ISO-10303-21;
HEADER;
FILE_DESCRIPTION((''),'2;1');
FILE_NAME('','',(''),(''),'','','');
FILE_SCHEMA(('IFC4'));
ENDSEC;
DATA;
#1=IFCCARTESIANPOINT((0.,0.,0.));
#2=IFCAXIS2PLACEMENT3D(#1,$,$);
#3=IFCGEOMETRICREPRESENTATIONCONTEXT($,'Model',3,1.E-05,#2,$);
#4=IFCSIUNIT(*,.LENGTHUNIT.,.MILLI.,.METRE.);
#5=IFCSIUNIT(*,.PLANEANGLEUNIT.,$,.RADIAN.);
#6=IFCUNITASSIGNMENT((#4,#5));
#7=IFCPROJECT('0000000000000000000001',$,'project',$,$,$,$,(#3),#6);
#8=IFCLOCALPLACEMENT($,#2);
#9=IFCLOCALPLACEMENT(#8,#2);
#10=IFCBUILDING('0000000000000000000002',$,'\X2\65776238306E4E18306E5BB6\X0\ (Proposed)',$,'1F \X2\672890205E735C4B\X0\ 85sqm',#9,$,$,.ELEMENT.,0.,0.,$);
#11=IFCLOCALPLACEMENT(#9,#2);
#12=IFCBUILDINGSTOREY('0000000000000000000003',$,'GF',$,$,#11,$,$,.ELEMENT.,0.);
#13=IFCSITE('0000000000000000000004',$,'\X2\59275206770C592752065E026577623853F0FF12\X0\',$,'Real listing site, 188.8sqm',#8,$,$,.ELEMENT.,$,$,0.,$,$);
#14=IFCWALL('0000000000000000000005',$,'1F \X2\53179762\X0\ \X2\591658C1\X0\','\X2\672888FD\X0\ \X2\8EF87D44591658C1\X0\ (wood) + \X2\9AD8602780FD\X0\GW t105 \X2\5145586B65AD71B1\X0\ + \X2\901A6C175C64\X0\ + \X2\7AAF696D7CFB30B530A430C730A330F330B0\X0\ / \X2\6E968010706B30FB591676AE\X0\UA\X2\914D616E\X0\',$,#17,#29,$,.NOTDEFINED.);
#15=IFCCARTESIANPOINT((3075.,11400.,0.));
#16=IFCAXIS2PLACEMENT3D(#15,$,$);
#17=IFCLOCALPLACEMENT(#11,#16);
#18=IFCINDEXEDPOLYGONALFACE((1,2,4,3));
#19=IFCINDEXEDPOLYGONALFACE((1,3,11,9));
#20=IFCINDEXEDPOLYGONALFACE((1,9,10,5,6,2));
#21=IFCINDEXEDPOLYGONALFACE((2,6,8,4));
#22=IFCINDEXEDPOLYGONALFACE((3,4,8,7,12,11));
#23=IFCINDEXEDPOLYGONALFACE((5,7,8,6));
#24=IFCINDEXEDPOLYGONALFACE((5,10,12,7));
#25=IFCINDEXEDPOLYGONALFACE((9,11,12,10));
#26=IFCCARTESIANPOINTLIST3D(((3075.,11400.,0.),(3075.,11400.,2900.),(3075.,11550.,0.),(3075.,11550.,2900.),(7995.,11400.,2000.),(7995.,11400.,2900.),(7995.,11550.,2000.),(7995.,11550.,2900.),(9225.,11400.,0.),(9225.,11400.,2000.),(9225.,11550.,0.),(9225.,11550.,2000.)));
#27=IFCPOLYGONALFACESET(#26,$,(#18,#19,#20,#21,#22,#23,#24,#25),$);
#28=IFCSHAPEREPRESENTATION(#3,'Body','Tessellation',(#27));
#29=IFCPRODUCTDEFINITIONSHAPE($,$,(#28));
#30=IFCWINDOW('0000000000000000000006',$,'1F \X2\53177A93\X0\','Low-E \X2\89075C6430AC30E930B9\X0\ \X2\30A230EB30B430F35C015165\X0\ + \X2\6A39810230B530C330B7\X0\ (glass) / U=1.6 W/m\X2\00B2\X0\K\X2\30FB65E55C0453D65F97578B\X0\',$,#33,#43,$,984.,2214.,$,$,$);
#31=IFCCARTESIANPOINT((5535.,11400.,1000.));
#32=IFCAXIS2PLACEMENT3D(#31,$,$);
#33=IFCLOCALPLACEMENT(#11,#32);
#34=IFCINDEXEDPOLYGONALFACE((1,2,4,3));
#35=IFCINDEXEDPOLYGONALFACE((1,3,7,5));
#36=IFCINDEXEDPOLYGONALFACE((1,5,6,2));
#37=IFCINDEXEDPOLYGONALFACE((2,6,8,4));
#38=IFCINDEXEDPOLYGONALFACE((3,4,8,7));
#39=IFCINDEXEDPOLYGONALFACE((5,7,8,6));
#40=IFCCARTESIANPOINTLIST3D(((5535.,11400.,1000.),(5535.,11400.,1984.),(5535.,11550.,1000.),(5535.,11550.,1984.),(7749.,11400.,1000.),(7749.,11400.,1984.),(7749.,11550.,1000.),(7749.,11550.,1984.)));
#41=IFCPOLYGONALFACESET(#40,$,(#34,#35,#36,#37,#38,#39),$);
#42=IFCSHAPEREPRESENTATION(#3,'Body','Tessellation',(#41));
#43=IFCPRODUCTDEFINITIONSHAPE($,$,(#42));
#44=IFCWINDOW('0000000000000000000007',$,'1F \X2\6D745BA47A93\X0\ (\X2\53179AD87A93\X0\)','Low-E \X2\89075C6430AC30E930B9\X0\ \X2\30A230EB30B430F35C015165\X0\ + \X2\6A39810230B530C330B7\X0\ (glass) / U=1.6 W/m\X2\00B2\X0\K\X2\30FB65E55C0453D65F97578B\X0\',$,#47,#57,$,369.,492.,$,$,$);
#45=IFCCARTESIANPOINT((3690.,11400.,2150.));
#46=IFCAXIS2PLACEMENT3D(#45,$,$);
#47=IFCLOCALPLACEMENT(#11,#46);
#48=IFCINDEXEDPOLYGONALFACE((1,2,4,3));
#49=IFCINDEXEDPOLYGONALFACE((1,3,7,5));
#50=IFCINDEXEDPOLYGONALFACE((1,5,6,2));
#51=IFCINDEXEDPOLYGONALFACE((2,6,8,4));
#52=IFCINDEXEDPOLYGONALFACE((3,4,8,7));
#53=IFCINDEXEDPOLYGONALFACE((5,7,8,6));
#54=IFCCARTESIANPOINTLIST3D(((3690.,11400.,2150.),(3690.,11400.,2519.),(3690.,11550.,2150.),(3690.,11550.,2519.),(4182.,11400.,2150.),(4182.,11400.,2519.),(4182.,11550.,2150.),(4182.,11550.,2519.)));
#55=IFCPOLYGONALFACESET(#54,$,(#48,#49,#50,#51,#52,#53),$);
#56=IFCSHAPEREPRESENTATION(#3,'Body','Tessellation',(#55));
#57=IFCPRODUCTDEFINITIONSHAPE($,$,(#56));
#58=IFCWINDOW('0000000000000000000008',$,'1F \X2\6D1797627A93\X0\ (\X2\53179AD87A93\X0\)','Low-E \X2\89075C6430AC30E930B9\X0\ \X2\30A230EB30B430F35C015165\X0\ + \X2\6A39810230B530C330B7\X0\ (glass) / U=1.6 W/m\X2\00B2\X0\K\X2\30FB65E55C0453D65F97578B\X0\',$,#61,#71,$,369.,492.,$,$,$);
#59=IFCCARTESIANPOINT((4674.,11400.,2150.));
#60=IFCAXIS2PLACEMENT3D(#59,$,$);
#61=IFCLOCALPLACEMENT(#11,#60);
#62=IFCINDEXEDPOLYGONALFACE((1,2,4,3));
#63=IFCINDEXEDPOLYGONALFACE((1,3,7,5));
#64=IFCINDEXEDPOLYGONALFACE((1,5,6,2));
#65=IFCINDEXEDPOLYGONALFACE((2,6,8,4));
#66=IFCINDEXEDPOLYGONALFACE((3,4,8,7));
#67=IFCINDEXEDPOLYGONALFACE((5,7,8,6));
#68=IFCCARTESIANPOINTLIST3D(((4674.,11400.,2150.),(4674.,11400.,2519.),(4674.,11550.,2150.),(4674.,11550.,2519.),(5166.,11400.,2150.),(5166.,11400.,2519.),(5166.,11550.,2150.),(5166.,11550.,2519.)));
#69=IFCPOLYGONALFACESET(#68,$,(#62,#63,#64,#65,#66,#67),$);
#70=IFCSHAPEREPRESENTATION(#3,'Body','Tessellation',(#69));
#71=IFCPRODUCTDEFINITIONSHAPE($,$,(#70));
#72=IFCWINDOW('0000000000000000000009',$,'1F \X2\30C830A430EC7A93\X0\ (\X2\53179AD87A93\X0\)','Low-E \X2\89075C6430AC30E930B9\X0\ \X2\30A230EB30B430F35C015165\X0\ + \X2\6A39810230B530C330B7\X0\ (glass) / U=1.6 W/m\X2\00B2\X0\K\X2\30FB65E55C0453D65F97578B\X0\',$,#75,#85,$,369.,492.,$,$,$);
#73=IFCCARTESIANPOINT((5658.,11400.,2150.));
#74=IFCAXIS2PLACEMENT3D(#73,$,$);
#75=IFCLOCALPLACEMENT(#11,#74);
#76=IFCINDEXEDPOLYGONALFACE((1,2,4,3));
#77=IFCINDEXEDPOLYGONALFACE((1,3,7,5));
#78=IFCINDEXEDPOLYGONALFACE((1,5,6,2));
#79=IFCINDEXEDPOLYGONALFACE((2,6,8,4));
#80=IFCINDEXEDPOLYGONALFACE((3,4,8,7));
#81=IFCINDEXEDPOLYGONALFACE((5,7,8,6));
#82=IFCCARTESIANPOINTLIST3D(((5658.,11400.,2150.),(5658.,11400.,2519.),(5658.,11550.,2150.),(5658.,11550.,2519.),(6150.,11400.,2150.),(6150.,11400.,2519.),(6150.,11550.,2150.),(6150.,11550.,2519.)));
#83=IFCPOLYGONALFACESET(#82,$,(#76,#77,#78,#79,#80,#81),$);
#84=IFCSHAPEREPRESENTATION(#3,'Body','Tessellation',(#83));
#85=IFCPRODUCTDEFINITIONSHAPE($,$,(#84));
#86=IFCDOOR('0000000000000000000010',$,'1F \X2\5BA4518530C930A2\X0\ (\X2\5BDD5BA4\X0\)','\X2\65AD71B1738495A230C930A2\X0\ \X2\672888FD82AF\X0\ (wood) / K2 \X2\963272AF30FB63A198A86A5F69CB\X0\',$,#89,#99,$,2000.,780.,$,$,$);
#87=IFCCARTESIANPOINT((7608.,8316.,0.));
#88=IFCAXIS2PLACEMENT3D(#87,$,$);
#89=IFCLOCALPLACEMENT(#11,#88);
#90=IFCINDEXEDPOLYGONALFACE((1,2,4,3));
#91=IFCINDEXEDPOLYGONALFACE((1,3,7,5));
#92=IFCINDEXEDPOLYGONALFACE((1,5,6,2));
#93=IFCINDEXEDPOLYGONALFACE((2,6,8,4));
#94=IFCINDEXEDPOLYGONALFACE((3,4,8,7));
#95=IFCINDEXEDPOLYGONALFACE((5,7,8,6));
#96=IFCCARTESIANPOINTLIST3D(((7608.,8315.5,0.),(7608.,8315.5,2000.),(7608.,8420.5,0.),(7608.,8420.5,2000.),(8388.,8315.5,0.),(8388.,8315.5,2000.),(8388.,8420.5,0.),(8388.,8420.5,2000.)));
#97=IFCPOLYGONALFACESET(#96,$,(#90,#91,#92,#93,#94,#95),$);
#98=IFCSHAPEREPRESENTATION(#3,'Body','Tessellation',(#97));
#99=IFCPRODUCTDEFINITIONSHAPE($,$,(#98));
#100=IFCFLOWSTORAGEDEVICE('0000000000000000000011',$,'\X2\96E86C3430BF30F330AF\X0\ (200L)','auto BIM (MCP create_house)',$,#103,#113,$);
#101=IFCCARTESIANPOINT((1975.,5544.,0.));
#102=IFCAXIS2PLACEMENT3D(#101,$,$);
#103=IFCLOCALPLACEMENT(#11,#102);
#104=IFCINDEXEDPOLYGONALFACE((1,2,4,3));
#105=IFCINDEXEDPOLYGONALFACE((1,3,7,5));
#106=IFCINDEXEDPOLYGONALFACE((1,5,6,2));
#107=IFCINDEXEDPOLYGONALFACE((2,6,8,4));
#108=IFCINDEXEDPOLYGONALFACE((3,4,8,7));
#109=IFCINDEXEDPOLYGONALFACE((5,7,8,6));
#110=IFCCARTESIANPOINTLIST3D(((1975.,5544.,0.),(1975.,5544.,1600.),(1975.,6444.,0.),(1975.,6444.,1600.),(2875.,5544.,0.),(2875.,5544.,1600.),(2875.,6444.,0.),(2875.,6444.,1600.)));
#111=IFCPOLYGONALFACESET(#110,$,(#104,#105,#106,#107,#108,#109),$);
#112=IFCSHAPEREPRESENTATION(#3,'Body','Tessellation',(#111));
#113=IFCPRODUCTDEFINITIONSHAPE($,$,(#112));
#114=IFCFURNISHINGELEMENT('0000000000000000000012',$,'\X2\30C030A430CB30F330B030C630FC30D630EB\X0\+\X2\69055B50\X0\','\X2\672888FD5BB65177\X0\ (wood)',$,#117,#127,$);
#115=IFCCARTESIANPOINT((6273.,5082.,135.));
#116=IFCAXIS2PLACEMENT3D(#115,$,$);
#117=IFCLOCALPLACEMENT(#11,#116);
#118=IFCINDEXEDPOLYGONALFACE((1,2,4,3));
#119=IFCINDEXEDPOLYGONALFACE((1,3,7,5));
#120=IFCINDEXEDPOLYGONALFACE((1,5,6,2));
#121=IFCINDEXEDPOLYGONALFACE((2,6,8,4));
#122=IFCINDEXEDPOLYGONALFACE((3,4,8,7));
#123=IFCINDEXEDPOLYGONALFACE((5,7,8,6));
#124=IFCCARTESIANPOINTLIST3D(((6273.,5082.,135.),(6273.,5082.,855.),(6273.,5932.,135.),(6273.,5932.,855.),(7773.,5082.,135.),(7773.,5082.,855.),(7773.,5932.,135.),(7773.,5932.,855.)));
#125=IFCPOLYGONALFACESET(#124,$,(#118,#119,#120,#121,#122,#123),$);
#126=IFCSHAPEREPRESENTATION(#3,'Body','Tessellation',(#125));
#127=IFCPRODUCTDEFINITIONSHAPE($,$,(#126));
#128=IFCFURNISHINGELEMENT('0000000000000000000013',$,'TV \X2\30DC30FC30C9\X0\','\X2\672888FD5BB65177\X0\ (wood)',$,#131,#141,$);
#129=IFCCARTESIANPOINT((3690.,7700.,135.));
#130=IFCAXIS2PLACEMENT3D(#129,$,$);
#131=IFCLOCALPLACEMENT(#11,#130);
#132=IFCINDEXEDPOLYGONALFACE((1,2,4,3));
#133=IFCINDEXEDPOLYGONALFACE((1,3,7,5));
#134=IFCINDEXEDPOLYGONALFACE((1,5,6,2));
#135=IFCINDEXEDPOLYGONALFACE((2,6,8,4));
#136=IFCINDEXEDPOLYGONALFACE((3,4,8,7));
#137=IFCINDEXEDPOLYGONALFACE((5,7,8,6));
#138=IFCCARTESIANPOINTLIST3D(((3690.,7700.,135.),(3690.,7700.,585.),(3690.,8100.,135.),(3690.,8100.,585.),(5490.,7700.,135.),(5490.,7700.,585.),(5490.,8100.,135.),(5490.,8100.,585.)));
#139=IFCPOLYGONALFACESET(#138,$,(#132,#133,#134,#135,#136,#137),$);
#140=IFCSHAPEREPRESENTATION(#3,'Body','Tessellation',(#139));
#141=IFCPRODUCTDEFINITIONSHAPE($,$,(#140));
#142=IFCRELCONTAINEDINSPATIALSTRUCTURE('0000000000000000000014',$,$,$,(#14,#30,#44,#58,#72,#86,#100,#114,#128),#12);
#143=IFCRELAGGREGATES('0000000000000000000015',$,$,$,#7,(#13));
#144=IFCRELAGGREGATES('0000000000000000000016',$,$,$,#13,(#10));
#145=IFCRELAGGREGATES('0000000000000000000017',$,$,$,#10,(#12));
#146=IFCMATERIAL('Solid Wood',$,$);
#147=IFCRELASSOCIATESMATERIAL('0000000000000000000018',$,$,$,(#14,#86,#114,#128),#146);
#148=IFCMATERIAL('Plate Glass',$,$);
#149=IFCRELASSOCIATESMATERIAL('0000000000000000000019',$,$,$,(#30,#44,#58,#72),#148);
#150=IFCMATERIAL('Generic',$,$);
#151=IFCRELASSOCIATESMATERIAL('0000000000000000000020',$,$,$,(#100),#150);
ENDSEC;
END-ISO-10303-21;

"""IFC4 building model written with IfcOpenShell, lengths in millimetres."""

from ifc_helpers import new_model, si_unit, frame, frame_2d, origin, place, context, project, spatial, rectangle, extrude, material, element, fill, save


model = new_model("IFC4")

# Units and contexts
model_context = context("Model", 3, precision=1e-05, world=origin())
ifc_project = project(units=[si_unit("LENGTHUNIT", "METRE", prefix="MILLI"), si_unit("PLANEANGLEUNIT", "RADIAN")], contexts=[model_context])

# Site, building, storey
site_placement = place(None, origin())
site = spatial("IfcSite", under=ifc_project, at=site_placement, Name="大分県大分市敷戸台２", ObjectType="Real listing site, 188.8sqm", CompositionType="ELEMENT", RefElevation=0.0)
building_placement = place(site_placement, origin())
building = spatial("IfcBuilding", under=site, at=building_placement, Name="敷戸の丘の家 (Proposed)", ObjectType="1F 木造平屋 85sqm", CompositionType="ELEMENT", ElevationOfRefHeight=0.0, ElevationOfTerrain=0.0)
storey_placement = place(building_placement, origin())
storey = spatial("IfcBuildingStorey", under=building, at=storey_placement, Name="GF", CompositionType="ELEMENT", Elevation=0.0)

# Wall, openings, windows
ifc_material_1 = material(Name="Solid Wood")
wall_1_placement = place(storey_placement, frame((3075.0, 11400.0, 0.0)))
wall_1 = element("IfcWall", 1, at=wall_1_placement, inside=storey, material=ifc_material_1, Name="1F 北面 外壁", Description="木製 軸組外壁 (wood) + 高性能GW t105 充填断熱 + 通気層 + 窯業系サイディング / 準耐火・外皮UA配慮", PredefinedType="NOTDEFINED", context=model_context, shape_type="SweptSolid", body=[
    extrude(rectangle(XDim=6150.0, YDim=150.0, at=frame_2d((3075.0, 75.0))), frame((3075.0, 11400.0, 0.0)), (0.0, 0.0, 1.0), 2900.0),
])
opening_1_placement = place(storey_placement, frame((5535.0, 11400.0, 1000.0)))
opening_1 = element("IfcOpeningElement", 2, at=opening_1_placement, cuts=wall_1, PredefinedType="NOTDEFINED", context=model_context, shape_type="SweptSolid", body=[
    extrude(rectangle(XDim=2214.0, YDim=150.0, at=frame_2d((1107.0, 75.0))), frame((5535.0, 11400.0, 1000.0)), (0.0, 0.0, 1.0), 984.0),
])
opening_2_placement = place(storey_placement, frame((3690.0, 11400.0, 2150.0)))
opening_2 = element("IfcOpeningElement", 3, at=opening_2_placement, cuts=wall_1, PredefinedType="NOTDEFINED", context=model_context, shape_type="SweptSolid", body=[
    extrude(rectangle(XDim=492.0, YDim=150.0, at=frame_2d((246.0, 75.0))), frame((3690.0, 11400.0, 2150.0)), (0.0, 0.0, 1.0), 369.0),
])
opening_3_placement = place(storey_placement, frame((4674.0, 11400.0, 2150.0)))
opening_3 = element("IfcOpeningElement", 4, at=opening_3_placement, cuts=wall_1, PredefinedType="NOTDEFINED", context=model_context, shape_type="SweptSolid", body=[
    extrude(rectangle(XDim=492.0, YDim=150.0, at=frame_2d((246.0, 75.0))), frame((4674.0, 11400.0, 2150.0)), (0.0, 0.0, 1.0), 369.0),
])
opening_4_placement = place(storey_placement, frame((5658.0, 11400.0, 2150.0)))
opening_4 = element("IfcOpeningElement", 5, at=opening_4_placement, cuts=wall_1, PredefinedType="NOTDEFINED", context=model_context, shape_type="SweptSolid", body=[
    extrude(rectangle(XDim=492.0, YDim=150.0, at=frame_2d((246.0, 75.0))), frame((5658.0, 11400.0, 2150.0)), (0.0, 0.0, 1.0), 369.0),
])
ifc_material_2 = material(Name="Plate Glass")
window_1_placement = place(storey_placement, frame((5535.0, 11400.0, 1000.0)))
window_1 = element("IfcWindow", 6, at=window_1_placement, inside=storey, material=ifc_material_2, Name="1F 北窓", Description="Low-E 複層ガラス アルゴン封入 + 樹脂サッシ (glass) / U=1.6 W/m²K・日射取得型", OverallHeight=984.0, OverallWidth=2214.0, context=model_context, shape_type="SweptSolid", body=[
    extrude(rectangle(XDim=2214.0, YDim=150.0, at=frame_2d((1107.0, 75.0))), frame((5535.0, 11400.0, 1000.0)), (0.0, 0.0, 1.0), 984.0),
])
fill(opening_1, window_1)
window_2_placement = place(storey_placement, frame((3690.0, 11400.0, 2150.0)))
window_2 = element("IfcWindow", 7, at=window_2_placement, inside=storey, material=ifc_material_2, Name="1F 浴室窓 (北高窓)", Description="Low-E 複層ガラス アルゴン封入 + 樹脂サッシ (glass) / U=1.6 W/m²K・日射取得型", OverallHeight=369.0, OverallWidth=492.0, context=model_context, shape_type="SweptSolid", body=[
    extrude(rectangle(XDim=492.0, YDim=150.0, at=frame_2d((246.0, 75.0))), frame((3690.0, 11400.0, 2150.0)), (0.0, 0.0, 1.0), 369.0),
])
fill(opening_2, window_2)
window_3_placement = place(storey_placement, frame((4674.0, 11400.0, 2150.0)))
window_3 = element("IfcWindow", 8, at=window_3_placement, inside=storey, material=ifc_material_2, Name="1F 洗面窓 (北高窓)", Description="Low-E 複層ガラス アルゴン封入 + 樹脂サッシ (glass) / U=1.6 W/m²K・日射取得型", OverallHeight=369.0, OverallWidth=492.0, context=model_context, shape_type="SweptSolid", body=[
    extrude(rectangle(XDim=492.0, YDim=150.0, at=frame_2d((246.0, 75.0))), frame((4674.0, 11400.0, 2150.0)), (0.0, 0.0, 1.0), 369.0),
])
fill(opening_3, window_3)
window_4_placement = place(storey_placement, frame((5658.0, 11400.0, 2150.0)))
window_4 = element("IfcWindow", 9, at=window_4_placement, inside=storey, material=ifc_material_2, Name="1F トイレ窓 (北高窓)", Description="Low-E 複層ガラス アルゴン封入 + 樹脂サッシ (glass) / U=1.6 W/m²K・日射取得型", OverallHeight=369.0, OverallWidth=492.0, context=model_context, shape_type="SweptSolid", body=[
    extrude(rectangle(XDim=492.0, YDim=150.0, at=frame_2d((246.0, 75.0))), frame((5658.0, 11400.0, 2150.0)), (0.0, 0.0, 1.0), 369.0),
])
fill(opening_4, window_4)

# Door
door_1_placement = place(storey_placement, frame((7608.0, 8316.0, 0.0)))
element("IfcDoor", 10, at=door_1_placement, inside=storey, material=ifc_material_1, Name="1F 室内ドア (寝室)", Description="断熱玄関ドア 木製芯 (wood) / K2 防犯・採風機構", OverallHeight=2000.0, OverallWidth=780.0, context=model_context, shape_type="SweptSolid", body=[
    extrude(rectangle(XDim=780.0, YDim=105.0, at=frame_2d((390.0, 52.0))), frame((7608.0, 8316.0, 0.0)), (0.0, 0.0, 1.0), 2000.0),
])

# Flow storage device
ifc_material_3 = material(Name="Generic")
flow_storage_device_placement = place(storey_placement, frame((1975.0, 5544.0, 0.0)))
element("IfcFlowStorageDevice", 11, at=flow_storage_device_placement, inside=storey, material=ifc_material_3, Name="雨水タンク (200L)", Description="auto BIM (MCP create_house)", context=model_context, shape_type="SweptSolid", body=[
    extrude(rectangle(XDim=900.0, YDim=900.0, at=frame_2d((450.0, 450.0))), frame((1975.0, 5544.0, 0.0)), (0.0, 0.0, 1.0), 1600.0),
])

# Furnishing elements
furnishing_1_placement = place(storey_placement, frame((6273.0, 5082.0, 135.0)))
element("IfcFurnishingElement", 12, at=furnishing_1_placement, inside=storey, material=ifc_material_1, Name="ダイニングテーブル+椅子", Description="木製家具 (wood)", context=model_context, shape_type="SweptSolid", body=[
    extrude(rectangle(XDim=1500.0, YDim=850.0, at=frame_2d((750.0, 425.0))), frame((6273.0, 5082.0, 135.0)), (0.0, 0.0, 1.0), 720.0),
])
furnishing_2_placement = place(storey_placement, frame((3690.0, 7700.0, 135.0)))
element("IfcFurnishingElement", 13, at=furnishing_2_placement, inside=storey, material=ifc_material_1, Name="TV ボード", Description="木製家具 (wood)", context=model_context, shape_type="SweptSolid", body=[
    extrude(rectangle(XDim=1800.0, YDim=400.0, at=frame_2d((900.0, 200.0))), frame((3690.0, 7700.0, 135.0)), (0.0, 0.0, 1.0), 450.0),
])

save(model, "model.ifc")
